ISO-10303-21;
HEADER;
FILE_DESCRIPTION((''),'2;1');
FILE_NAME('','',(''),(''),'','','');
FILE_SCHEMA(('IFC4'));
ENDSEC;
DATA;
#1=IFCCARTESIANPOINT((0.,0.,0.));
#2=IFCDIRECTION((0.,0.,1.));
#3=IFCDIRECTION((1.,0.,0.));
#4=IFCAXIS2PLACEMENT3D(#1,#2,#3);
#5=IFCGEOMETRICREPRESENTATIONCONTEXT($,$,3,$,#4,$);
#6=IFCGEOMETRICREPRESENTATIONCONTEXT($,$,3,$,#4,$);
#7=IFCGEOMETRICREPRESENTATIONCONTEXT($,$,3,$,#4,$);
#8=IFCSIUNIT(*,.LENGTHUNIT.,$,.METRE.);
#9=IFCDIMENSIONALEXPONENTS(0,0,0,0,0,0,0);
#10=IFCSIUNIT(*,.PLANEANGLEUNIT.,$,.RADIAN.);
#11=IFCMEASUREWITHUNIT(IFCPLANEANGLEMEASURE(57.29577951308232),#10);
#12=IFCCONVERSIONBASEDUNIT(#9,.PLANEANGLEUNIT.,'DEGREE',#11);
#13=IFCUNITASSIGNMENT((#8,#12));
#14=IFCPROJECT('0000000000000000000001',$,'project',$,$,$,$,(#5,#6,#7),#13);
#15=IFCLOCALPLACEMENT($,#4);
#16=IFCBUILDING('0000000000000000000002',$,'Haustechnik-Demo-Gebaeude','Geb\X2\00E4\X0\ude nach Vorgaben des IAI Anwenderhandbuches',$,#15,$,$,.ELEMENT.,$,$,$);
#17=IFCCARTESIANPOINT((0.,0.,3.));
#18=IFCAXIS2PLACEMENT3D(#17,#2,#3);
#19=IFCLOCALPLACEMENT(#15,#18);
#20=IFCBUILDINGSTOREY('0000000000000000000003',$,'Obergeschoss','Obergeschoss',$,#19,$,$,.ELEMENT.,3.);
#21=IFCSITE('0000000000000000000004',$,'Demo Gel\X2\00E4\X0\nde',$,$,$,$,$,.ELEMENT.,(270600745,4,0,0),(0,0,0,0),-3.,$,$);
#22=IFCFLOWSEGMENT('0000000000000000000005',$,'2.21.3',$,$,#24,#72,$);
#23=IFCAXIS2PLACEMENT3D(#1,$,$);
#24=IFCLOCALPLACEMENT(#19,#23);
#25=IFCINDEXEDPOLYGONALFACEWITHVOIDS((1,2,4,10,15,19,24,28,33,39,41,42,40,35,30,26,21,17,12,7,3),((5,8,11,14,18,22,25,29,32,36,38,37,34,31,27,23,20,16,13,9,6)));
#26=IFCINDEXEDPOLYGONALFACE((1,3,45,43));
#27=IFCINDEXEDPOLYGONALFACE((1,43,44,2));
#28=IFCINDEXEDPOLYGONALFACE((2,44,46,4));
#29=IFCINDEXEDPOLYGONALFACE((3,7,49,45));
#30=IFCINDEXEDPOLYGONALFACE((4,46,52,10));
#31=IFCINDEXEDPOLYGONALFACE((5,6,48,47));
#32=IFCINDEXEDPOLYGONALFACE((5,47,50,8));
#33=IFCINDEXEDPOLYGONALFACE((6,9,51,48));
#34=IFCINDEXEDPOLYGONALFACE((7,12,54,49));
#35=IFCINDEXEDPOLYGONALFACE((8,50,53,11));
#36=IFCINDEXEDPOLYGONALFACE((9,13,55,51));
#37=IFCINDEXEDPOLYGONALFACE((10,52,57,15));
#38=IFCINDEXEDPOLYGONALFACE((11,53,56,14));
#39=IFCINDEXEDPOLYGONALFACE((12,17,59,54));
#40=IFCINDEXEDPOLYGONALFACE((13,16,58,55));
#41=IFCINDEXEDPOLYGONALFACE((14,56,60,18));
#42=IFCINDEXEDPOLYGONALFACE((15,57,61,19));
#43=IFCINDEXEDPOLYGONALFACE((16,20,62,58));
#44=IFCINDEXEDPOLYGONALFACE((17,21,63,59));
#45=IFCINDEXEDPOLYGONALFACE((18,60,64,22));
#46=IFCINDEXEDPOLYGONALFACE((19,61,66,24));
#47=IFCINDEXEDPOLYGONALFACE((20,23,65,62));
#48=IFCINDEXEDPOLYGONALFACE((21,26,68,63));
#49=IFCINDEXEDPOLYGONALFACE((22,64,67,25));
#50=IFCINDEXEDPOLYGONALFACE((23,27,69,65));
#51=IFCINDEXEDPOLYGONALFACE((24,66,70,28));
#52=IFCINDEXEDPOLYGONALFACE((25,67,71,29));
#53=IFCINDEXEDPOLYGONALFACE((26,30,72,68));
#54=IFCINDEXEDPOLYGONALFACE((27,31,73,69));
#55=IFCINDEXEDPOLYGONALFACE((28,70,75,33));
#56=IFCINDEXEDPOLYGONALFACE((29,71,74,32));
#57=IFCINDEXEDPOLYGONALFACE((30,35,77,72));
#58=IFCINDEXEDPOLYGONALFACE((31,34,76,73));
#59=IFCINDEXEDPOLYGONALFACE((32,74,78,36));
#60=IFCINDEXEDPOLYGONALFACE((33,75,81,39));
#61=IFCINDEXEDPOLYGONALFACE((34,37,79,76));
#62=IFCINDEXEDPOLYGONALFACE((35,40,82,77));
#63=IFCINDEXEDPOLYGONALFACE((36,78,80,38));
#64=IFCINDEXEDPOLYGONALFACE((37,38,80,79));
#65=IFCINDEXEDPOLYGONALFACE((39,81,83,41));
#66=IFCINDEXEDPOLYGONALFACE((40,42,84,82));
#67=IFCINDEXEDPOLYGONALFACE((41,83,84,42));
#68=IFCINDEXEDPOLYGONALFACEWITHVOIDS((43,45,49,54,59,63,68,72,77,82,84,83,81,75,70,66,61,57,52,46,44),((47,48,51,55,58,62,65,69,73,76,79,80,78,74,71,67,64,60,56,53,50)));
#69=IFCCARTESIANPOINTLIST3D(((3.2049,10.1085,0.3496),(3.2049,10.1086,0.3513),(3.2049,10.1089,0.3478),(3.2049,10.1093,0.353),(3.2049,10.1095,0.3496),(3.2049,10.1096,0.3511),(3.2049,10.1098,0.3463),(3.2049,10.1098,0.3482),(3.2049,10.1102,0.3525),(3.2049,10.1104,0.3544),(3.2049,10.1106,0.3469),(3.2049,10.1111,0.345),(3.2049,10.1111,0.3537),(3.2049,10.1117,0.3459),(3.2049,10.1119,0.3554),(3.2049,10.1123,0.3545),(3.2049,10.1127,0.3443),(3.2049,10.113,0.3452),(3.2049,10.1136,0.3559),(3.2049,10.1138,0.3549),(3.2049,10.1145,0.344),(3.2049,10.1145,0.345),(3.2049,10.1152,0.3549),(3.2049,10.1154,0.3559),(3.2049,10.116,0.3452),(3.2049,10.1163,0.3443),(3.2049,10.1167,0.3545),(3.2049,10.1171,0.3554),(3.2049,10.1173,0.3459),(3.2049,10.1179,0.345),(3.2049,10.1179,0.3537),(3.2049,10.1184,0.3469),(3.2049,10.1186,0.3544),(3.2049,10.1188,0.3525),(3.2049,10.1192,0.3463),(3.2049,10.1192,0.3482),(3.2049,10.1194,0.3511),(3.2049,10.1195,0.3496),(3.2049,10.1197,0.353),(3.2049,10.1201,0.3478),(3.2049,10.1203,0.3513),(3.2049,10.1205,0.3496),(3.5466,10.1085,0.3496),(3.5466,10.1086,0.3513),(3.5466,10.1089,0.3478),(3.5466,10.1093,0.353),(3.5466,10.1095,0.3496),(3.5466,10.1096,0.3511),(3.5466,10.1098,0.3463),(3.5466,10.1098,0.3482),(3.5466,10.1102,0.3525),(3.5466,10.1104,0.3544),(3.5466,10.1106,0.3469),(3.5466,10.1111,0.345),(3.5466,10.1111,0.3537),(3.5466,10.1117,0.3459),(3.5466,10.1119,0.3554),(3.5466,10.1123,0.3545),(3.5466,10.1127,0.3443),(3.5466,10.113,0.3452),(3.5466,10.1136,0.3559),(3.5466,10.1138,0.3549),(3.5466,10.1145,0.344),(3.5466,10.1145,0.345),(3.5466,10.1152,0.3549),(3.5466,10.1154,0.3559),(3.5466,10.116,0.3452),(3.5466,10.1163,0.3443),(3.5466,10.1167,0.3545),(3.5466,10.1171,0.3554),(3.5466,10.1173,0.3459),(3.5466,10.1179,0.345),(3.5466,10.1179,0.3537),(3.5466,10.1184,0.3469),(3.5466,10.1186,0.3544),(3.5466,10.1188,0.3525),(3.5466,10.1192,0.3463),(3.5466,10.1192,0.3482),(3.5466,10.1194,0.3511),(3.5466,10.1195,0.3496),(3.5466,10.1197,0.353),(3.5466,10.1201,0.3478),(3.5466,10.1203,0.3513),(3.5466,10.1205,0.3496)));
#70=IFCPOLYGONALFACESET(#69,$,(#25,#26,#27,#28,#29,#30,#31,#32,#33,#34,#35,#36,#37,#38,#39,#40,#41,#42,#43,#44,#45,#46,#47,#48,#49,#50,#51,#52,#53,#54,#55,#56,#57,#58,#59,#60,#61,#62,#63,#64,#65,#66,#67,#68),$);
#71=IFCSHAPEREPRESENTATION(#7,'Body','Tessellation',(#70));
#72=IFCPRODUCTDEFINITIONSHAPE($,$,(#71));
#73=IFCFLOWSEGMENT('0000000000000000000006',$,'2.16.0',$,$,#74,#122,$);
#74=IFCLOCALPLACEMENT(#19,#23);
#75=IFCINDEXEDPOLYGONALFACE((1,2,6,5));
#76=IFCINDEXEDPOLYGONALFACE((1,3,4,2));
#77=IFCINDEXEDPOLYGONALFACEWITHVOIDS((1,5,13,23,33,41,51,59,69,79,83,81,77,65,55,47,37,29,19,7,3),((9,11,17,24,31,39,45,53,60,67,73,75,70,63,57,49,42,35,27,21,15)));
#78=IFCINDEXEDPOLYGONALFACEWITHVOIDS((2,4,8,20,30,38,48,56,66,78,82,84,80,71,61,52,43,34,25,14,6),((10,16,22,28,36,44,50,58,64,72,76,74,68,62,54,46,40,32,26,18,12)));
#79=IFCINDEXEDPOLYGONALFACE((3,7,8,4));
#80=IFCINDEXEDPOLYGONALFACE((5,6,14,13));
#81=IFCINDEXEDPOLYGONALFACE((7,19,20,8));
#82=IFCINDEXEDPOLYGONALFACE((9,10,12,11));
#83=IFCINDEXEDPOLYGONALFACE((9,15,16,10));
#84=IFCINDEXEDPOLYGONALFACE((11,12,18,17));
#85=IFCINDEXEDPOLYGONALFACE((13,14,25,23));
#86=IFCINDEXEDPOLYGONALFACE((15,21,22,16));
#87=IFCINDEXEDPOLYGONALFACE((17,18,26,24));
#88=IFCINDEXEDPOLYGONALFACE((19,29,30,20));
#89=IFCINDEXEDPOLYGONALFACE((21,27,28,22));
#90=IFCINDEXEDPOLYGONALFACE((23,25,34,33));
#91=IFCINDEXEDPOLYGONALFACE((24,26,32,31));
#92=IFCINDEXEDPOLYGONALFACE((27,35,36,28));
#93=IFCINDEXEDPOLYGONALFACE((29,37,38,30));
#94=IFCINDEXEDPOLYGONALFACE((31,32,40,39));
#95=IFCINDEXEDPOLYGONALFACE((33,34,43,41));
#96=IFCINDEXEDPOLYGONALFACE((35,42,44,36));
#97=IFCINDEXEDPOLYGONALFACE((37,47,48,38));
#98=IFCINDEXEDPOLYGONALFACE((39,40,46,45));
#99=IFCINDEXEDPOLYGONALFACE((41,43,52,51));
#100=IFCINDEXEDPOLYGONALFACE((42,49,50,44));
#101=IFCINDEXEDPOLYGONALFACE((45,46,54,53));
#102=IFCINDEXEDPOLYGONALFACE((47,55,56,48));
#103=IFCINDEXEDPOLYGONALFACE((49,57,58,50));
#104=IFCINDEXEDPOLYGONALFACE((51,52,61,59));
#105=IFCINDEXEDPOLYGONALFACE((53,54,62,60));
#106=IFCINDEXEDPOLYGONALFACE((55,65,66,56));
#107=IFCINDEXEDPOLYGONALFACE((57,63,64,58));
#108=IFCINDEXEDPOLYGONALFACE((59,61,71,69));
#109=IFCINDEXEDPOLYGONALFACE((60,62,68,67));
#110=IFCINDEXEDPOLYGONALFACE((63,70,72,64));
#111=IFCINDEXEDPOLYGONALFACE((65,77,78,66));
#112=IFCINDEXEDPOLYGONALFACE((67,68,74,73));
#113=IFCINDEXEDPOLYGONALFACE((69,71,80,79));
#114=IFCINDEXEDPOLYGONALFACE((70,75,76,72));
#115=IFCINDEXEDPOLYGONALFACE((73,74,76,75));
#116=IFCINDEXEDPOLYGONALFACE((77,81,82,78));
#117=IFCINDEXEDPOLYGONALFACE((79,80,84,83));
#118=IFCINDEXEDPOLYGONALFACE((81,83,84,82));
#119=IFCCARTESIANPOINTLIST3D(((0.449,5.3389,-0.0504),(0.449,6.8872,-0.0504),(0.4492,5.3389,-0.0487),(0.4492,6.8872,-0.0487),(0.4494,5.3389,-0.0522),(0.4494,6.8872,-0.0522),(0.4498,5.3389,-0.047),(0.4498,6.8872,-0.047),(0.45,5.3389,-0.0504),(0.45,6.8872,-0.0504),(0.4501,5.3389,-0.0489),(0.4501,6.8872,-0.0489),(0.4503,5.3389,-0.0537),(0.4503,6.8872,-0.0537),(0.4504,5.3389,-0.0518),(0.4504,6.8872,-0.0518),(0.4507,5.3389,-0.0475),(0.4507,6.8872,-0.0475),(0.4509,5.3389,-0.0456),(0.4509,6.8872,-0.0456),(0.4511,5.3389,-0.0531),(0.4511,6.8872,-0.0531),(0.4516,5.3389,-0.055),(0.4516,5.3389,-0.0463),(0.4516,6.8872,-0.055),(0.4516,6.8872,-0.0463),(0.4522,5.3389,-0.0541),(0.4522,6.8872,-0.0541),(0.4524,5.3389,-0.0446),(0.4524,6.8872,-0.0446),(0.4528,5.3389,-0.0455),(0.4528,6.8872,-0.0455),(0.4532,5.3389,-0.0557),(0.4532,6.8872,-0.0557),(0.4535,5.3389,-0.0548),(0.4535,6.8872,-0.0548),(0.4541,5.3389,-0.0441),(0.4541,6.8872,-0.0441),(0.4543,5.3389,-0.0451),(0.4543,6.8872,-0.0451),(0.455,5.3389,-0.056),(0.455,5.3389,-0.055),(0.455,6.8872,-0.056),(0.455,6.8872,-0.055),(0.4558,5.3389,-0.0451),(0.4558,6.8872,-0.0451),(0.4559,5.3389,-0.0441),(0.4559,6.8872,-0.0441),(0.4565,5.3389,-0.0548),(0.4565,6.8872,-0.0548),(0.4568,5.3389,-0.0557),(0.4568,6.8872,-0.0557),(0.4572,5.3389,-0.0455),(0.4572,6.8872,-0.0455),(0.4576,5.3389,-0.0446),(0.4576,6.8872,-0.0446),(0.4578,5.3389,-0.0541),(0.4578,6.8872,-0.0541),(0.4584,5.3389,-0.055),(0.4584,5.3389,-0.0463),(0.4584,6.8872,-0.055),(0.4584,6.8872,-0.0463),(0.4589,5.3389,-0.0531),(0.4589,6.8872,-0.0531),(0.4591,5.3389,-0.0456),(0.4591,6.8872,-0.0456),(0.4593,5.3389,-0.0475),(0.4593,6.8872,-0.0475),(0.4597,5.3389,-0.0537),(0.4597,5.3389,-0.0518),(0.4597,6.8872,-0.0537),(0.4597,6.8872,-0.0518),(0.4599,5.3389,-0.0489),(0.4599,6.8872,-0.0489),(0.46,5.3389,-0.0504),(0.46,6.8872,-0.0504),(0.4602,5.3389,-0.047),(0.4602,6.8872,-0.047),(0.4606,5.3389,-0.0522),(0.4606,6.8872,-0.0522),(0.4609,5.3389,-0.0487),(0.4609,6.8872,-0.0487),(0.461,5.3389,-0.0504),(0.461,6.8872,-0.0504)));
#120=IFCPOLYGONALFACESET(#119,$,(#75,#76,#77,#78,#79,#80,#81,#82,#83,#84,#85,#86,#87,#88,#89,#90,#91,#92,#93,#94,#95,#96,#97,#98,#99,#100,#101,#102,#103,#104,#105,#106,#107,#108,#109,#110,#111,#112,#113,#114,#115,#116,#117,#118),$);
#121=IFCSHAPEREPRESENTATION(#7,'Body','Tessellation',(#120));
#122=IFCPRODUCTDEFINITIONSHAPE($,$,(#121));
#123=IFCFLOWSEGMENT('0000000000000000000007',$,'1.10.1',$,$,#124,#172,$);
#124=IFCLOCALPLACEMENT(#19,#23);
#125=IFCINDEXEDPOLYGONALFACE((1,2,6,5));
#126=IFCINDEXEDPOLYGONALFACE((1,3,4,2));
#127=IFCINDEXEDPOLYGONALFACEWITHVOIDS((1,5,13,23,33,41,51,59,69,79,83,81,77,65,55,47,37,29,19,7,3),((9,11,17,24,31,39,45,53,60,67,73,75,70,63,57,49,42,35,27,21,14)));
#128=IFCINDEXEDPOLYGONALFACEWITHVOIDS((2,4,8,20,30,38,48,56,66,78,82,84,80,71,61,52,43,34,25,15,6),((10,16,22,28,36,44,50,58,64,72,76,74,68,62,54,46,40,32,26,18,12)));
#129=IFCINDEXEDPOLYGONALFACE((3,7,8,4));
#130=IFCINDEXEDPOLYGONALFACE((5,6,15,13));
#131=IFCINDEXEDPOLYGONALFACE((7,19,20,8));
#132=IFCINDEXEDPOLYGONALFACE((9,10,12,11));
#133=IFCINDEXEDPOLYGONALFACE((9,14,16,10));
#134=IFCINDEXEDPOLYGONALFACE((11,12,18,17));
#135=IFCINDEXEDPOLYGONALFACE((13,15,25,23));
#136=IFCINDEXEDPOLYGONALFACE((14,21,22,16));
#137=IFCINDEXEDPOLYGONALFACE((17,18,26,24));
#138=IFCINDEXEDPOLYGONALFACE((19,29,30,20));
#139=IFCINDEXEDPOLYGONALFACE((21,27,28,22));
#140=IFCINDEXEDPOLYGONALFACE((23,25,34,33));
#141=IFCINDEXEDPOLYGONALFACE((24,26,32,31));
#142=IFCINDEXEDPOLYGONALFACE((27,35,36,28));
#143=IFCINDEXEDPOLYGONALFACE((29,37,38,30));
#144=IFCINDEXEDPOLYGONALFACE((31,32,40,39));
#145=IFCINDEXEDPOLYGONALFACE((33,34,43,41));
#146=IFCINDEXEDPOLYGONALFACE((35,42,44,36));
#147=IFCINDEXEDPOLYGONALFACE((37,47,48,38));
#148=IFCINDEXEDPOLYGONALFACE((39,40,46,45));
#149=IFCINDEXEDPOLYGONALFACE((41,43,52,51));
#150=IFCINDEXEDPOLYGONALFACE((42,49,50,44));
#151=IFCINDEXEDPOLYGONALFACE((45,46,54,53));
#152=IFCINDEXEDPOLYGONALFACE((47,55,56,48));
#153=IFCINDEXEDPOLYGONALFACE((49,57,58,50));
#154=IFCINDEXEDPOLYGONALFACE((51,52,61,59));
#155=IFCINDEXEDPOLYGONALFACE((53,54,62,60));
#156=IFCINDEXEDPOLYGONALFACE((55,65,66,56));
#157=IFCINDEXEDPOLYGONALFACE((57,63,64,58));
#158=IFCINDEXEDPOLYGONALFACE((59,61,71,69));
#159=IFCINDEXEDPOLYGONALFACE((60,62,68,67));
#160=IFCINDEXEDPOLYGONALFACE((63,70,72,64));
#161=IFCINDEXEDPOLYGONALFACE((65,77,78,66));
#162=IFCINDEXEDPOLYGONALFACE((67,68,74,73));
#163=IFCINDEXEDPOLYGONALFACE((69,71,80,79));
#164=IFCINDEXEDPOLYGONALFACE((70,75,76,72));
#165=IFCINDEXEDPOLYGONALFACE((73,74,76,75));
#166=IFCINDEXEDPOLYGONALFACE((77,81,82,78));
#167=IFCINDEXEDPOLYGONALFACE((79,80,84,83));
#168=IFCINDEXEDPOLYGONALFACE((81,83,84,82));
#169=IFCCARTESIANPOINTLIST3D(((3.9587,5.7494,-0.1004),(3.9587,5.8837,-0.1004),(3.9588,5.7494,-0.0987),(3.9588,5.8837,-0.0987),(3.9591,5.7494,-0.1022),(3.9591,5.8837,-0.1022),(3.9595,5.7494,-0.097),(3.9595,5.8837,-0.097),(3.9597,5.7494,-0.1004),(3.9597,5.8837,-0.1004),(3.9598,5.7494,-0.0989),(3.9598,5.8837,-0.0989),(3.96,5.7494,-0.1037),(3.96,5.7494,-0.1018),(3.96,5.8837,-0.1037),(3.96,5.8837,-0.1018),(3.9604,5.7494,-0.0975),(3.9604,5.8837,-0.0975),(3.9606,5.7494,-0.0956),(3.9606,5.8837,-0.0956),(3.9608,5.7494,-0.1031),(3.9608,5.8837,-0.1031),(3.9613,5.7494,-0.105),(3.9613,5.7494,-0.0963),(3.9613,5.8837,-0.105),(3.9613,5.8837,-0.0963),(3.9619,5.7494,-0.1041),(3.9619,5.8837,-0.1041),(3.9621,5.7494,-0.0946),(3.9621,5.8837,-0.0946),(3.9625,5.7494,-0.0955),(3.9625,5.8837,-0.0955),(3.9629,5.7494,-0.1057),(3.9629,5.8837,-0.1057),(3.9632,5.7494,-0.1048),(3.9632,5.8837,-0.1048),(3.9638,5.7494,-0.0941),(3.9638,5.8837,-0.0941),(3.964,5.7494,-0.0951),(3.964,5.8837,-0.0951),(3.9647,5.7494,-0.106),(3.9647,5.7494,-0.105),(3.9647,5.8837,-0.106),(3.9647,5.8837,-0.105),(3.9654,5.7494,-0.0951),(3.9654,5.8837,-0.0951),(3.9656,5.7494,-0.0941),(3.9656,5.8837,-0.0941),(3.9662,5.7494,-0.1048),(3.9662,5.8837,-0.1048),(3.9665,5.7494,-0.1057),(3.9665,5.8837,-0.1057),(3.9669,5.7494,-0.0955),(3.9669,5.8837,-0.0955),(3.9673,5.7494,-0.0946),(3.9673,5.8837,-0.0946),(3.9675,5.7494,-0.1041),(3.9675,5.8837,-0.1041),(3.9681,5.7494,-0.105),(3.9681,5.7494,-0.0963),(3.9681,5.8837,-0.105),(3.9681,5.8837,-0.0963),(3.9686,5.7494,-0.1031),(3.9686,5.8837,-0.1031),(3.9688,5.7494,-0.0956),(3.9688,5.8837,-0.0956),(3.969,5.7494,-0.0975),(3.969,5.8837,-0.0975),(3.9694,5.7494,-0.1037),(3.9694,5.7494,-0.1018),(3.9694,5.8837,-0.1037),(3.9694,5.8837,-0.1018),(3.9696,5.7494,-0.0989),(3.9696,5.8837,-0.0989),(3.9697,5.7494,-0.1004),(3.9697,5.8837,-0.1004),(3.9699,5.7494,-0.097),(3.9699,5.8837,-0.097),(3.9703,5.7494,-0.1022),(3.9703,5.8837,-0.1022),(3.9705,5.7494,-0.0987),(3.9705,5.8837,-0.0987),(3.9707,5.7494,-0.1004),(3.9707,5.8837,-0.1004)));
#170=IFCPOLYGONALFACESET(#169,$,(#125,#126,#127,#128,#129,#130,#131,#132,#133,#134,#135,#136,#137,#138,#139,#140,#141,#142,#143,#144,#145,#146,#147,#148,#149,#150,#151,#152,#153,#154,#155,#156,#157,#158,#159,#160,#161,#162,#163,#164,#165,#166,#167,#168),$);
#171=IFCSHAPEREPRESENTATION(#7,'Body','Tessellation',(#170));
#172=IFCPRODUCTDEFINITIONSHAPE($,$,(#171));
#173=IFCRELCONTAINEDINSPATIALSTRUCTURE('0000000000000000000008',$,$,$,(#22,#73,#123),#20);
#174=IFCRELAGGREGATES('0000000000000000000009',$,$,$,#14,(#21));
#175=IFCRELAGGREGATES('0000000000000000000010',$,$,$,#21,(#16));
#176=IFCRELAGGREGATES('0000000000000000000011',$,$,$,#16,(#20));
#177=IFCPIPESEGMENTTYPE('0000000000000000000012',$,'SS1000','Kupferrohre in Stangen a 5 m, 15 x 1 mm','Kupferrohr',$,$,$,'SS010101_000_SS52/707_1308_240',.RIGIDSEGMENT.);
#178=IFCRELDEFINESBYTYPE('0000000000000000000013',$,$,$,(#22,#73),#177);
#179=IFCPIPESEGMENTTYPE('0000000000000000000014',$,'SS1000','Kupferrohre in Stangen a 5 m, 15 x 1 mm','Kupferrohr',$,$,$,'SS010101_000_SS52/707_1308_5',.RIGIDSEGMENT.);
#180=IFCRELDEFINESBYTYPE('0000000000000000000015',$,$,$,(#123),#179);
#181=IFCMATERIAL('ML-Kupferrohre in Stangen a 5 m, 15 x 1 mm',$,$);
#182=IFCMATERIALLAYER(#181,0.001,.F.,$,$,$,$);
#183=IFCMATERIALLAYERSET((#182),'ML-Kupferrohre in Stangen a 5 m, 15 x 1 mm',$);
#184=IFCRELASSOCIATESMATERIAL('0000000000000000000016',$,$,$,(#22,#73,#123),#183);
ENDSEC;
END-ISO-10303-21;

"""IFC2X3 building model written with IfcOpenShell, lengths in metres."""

from ifc_helpers import new_model, entity, si_unit, converted_unit, frame, origin_with_axes, origin_2d_with_axis, place, context, project, spatial, hollow_circle, extrude, material, layer, layer_set, layer_usage, type_object, element, save


model = new_model("IFC2X3")

# Units and contexts
context_of_model_1 = context(None, 3, world=origin_with_axes())
context_of_model_2 = context(None, 3, world=origin_with_axes())
context_of_model_3 = context(None, 3, world=origin_with_axes())
ifc_project = project(units=[si_unit("LENGTHUNIT", "METRE"), converted_unit("PLANEANGLEUNIT", "DEGREE", entity("IfcPlaneAngleMeasure", 57.29577951308232), si_unit("PLANEANGLEUNIT", "RADIAN"), dimensions=[0, 0, 0, 0, 0, 0, 0])], contexts=[context_of_model_1, context_of_model_2, context_of_model_3])

# Site, building, storey
site = spatial("IfcSite", under=ifc_project, Name="Demo Gelände", CompositionType="ELEMENT", RefLatitude=(270600745, 4, 0, 0), RefLongitude=(0, 0, 0, 0), RefElevation=-3.0)
building_placement = place(None, origin_with_axes())
building = spatial("IfcBuilding", under=site, at=building_placement, Name="Haustechnik-Demo-Gebaeude", Description="Gebäude nach Vorgaben des IAI Anwenderhandbuches", CompositionType="ELEMENT")
storey_placement = place(building_placement, frame((0.0, 0.0, 3.0), z_axis=(0.0, 0.0, 1.0), x_axis=(1.0, 0.0, 0.0)))
storey = spatial("IfcBuildingStorey", under=building, at=storey_placement, Name="Obergeschoss", Description="Obergeschoss", CompositionType="ELEMENT", Elevation=3.0)

# Flow segments
ifc_material = material(Name="ML-Kupferrohre in Stangen a 5 m, 15 x 1 mm")
ifc_layer = layer(ifc_material, 0.001, ventilated=False)
ifc_layer_set = layer_set([ifc_layer], Name="ML-Kupferrohre in Stangen a 5 m, 15 x 1 mm")
ifc_layer_usage = layer_usage(ifc_layer_set, "AXIS2", "POSITIVE", 0.0)
pipe_segment_type_1 = type_object("IfcPipeSegmentType", Name="SS1000", Description="Kupferrohre in Stangen a 5 m, 15 x 1 mm", ApplicableOccurrence="Kupferrohr", ElementType="SS010101_000_SS52/707_1308_240", PredefinedType="RIGIDSEGMENT")
flow_segment_1_placement = place(storey_placement, frame((3.5466, 10.1145, 0.35), z_axis=(-1.0, -0.000001, 0.0), x_axis=(0.0, 0.0, -1.0)))
element("IfcFlowSegment", 1, at=flow_segment_1_placement, inside=storey, type_object=pipe_segment_type_1, material=ifc_layer_usage, Name="2.21.3", context=context_of_model_3, shape_type="SweptSolid", body=[
    extrude(hollow_circle(Radius=0.006, WallThickness=0.001, at=origin_2d_with_axis()), origin_with_axes(), (0.0, 0.0, 1.0), 0.3417),
])
flow_segment_2_placement = place(storey_placement, frame((0.455, 5.3389, -0.05), z_axis=(0.0, 1.0, 0.0), x_axis=(0.0, 0.0, -1.0)))
element("IfcFlowSegment", 2, at=flow_segment_2_placement, inside=storey, type_object=pipe_segment_type_1, material=ifc_layer_usage, Name="2.16.0", context=context_of_model_3, shape_type="SweptSolid", body=[
    extrude(hollow_circle(Radius=0.006, WallThickness=0.001, at=origin_2d_with_axis()), origin_with_axes(), (0.0, 0.0, 1.0), 1.5483),
])
pipe_segment_type_2 = type_object("IfcPipeSegmentType", Name="SS1000", Description="Kupferrohre in Stangen a 5 m, 15 x 1 mm", ApplicableOccurrence="Kupferrohr", ElementType="SS010101_000_SS52/707_1308_5", PredefinedType="RIGIDSEGMENT")
flow_segment_3_placement = place(storey_placement, frame((3.9647, 5.8837, -0.1), z_axis=(0.0, -1.0, 0.0), x_axis=(0.0, 0.0, -1.0)))
element("IfcFlowSegment", 3, at=flow_segment_3_placement, inside=storey, type_object=pipe_segment_type_2, material=ifc_layer_usage, Name="1.10.1", context=context_of_model_3, shape_type="SweptSolid", body=[
    extrude(hollow_circle(Radius=0.006, WallThickness=0.001, at=origin_2d_with_axis()), origin_with_axes(), (0.0, 0.0, 1.0), 0.1343),
])

save(model, "model.ifc")
